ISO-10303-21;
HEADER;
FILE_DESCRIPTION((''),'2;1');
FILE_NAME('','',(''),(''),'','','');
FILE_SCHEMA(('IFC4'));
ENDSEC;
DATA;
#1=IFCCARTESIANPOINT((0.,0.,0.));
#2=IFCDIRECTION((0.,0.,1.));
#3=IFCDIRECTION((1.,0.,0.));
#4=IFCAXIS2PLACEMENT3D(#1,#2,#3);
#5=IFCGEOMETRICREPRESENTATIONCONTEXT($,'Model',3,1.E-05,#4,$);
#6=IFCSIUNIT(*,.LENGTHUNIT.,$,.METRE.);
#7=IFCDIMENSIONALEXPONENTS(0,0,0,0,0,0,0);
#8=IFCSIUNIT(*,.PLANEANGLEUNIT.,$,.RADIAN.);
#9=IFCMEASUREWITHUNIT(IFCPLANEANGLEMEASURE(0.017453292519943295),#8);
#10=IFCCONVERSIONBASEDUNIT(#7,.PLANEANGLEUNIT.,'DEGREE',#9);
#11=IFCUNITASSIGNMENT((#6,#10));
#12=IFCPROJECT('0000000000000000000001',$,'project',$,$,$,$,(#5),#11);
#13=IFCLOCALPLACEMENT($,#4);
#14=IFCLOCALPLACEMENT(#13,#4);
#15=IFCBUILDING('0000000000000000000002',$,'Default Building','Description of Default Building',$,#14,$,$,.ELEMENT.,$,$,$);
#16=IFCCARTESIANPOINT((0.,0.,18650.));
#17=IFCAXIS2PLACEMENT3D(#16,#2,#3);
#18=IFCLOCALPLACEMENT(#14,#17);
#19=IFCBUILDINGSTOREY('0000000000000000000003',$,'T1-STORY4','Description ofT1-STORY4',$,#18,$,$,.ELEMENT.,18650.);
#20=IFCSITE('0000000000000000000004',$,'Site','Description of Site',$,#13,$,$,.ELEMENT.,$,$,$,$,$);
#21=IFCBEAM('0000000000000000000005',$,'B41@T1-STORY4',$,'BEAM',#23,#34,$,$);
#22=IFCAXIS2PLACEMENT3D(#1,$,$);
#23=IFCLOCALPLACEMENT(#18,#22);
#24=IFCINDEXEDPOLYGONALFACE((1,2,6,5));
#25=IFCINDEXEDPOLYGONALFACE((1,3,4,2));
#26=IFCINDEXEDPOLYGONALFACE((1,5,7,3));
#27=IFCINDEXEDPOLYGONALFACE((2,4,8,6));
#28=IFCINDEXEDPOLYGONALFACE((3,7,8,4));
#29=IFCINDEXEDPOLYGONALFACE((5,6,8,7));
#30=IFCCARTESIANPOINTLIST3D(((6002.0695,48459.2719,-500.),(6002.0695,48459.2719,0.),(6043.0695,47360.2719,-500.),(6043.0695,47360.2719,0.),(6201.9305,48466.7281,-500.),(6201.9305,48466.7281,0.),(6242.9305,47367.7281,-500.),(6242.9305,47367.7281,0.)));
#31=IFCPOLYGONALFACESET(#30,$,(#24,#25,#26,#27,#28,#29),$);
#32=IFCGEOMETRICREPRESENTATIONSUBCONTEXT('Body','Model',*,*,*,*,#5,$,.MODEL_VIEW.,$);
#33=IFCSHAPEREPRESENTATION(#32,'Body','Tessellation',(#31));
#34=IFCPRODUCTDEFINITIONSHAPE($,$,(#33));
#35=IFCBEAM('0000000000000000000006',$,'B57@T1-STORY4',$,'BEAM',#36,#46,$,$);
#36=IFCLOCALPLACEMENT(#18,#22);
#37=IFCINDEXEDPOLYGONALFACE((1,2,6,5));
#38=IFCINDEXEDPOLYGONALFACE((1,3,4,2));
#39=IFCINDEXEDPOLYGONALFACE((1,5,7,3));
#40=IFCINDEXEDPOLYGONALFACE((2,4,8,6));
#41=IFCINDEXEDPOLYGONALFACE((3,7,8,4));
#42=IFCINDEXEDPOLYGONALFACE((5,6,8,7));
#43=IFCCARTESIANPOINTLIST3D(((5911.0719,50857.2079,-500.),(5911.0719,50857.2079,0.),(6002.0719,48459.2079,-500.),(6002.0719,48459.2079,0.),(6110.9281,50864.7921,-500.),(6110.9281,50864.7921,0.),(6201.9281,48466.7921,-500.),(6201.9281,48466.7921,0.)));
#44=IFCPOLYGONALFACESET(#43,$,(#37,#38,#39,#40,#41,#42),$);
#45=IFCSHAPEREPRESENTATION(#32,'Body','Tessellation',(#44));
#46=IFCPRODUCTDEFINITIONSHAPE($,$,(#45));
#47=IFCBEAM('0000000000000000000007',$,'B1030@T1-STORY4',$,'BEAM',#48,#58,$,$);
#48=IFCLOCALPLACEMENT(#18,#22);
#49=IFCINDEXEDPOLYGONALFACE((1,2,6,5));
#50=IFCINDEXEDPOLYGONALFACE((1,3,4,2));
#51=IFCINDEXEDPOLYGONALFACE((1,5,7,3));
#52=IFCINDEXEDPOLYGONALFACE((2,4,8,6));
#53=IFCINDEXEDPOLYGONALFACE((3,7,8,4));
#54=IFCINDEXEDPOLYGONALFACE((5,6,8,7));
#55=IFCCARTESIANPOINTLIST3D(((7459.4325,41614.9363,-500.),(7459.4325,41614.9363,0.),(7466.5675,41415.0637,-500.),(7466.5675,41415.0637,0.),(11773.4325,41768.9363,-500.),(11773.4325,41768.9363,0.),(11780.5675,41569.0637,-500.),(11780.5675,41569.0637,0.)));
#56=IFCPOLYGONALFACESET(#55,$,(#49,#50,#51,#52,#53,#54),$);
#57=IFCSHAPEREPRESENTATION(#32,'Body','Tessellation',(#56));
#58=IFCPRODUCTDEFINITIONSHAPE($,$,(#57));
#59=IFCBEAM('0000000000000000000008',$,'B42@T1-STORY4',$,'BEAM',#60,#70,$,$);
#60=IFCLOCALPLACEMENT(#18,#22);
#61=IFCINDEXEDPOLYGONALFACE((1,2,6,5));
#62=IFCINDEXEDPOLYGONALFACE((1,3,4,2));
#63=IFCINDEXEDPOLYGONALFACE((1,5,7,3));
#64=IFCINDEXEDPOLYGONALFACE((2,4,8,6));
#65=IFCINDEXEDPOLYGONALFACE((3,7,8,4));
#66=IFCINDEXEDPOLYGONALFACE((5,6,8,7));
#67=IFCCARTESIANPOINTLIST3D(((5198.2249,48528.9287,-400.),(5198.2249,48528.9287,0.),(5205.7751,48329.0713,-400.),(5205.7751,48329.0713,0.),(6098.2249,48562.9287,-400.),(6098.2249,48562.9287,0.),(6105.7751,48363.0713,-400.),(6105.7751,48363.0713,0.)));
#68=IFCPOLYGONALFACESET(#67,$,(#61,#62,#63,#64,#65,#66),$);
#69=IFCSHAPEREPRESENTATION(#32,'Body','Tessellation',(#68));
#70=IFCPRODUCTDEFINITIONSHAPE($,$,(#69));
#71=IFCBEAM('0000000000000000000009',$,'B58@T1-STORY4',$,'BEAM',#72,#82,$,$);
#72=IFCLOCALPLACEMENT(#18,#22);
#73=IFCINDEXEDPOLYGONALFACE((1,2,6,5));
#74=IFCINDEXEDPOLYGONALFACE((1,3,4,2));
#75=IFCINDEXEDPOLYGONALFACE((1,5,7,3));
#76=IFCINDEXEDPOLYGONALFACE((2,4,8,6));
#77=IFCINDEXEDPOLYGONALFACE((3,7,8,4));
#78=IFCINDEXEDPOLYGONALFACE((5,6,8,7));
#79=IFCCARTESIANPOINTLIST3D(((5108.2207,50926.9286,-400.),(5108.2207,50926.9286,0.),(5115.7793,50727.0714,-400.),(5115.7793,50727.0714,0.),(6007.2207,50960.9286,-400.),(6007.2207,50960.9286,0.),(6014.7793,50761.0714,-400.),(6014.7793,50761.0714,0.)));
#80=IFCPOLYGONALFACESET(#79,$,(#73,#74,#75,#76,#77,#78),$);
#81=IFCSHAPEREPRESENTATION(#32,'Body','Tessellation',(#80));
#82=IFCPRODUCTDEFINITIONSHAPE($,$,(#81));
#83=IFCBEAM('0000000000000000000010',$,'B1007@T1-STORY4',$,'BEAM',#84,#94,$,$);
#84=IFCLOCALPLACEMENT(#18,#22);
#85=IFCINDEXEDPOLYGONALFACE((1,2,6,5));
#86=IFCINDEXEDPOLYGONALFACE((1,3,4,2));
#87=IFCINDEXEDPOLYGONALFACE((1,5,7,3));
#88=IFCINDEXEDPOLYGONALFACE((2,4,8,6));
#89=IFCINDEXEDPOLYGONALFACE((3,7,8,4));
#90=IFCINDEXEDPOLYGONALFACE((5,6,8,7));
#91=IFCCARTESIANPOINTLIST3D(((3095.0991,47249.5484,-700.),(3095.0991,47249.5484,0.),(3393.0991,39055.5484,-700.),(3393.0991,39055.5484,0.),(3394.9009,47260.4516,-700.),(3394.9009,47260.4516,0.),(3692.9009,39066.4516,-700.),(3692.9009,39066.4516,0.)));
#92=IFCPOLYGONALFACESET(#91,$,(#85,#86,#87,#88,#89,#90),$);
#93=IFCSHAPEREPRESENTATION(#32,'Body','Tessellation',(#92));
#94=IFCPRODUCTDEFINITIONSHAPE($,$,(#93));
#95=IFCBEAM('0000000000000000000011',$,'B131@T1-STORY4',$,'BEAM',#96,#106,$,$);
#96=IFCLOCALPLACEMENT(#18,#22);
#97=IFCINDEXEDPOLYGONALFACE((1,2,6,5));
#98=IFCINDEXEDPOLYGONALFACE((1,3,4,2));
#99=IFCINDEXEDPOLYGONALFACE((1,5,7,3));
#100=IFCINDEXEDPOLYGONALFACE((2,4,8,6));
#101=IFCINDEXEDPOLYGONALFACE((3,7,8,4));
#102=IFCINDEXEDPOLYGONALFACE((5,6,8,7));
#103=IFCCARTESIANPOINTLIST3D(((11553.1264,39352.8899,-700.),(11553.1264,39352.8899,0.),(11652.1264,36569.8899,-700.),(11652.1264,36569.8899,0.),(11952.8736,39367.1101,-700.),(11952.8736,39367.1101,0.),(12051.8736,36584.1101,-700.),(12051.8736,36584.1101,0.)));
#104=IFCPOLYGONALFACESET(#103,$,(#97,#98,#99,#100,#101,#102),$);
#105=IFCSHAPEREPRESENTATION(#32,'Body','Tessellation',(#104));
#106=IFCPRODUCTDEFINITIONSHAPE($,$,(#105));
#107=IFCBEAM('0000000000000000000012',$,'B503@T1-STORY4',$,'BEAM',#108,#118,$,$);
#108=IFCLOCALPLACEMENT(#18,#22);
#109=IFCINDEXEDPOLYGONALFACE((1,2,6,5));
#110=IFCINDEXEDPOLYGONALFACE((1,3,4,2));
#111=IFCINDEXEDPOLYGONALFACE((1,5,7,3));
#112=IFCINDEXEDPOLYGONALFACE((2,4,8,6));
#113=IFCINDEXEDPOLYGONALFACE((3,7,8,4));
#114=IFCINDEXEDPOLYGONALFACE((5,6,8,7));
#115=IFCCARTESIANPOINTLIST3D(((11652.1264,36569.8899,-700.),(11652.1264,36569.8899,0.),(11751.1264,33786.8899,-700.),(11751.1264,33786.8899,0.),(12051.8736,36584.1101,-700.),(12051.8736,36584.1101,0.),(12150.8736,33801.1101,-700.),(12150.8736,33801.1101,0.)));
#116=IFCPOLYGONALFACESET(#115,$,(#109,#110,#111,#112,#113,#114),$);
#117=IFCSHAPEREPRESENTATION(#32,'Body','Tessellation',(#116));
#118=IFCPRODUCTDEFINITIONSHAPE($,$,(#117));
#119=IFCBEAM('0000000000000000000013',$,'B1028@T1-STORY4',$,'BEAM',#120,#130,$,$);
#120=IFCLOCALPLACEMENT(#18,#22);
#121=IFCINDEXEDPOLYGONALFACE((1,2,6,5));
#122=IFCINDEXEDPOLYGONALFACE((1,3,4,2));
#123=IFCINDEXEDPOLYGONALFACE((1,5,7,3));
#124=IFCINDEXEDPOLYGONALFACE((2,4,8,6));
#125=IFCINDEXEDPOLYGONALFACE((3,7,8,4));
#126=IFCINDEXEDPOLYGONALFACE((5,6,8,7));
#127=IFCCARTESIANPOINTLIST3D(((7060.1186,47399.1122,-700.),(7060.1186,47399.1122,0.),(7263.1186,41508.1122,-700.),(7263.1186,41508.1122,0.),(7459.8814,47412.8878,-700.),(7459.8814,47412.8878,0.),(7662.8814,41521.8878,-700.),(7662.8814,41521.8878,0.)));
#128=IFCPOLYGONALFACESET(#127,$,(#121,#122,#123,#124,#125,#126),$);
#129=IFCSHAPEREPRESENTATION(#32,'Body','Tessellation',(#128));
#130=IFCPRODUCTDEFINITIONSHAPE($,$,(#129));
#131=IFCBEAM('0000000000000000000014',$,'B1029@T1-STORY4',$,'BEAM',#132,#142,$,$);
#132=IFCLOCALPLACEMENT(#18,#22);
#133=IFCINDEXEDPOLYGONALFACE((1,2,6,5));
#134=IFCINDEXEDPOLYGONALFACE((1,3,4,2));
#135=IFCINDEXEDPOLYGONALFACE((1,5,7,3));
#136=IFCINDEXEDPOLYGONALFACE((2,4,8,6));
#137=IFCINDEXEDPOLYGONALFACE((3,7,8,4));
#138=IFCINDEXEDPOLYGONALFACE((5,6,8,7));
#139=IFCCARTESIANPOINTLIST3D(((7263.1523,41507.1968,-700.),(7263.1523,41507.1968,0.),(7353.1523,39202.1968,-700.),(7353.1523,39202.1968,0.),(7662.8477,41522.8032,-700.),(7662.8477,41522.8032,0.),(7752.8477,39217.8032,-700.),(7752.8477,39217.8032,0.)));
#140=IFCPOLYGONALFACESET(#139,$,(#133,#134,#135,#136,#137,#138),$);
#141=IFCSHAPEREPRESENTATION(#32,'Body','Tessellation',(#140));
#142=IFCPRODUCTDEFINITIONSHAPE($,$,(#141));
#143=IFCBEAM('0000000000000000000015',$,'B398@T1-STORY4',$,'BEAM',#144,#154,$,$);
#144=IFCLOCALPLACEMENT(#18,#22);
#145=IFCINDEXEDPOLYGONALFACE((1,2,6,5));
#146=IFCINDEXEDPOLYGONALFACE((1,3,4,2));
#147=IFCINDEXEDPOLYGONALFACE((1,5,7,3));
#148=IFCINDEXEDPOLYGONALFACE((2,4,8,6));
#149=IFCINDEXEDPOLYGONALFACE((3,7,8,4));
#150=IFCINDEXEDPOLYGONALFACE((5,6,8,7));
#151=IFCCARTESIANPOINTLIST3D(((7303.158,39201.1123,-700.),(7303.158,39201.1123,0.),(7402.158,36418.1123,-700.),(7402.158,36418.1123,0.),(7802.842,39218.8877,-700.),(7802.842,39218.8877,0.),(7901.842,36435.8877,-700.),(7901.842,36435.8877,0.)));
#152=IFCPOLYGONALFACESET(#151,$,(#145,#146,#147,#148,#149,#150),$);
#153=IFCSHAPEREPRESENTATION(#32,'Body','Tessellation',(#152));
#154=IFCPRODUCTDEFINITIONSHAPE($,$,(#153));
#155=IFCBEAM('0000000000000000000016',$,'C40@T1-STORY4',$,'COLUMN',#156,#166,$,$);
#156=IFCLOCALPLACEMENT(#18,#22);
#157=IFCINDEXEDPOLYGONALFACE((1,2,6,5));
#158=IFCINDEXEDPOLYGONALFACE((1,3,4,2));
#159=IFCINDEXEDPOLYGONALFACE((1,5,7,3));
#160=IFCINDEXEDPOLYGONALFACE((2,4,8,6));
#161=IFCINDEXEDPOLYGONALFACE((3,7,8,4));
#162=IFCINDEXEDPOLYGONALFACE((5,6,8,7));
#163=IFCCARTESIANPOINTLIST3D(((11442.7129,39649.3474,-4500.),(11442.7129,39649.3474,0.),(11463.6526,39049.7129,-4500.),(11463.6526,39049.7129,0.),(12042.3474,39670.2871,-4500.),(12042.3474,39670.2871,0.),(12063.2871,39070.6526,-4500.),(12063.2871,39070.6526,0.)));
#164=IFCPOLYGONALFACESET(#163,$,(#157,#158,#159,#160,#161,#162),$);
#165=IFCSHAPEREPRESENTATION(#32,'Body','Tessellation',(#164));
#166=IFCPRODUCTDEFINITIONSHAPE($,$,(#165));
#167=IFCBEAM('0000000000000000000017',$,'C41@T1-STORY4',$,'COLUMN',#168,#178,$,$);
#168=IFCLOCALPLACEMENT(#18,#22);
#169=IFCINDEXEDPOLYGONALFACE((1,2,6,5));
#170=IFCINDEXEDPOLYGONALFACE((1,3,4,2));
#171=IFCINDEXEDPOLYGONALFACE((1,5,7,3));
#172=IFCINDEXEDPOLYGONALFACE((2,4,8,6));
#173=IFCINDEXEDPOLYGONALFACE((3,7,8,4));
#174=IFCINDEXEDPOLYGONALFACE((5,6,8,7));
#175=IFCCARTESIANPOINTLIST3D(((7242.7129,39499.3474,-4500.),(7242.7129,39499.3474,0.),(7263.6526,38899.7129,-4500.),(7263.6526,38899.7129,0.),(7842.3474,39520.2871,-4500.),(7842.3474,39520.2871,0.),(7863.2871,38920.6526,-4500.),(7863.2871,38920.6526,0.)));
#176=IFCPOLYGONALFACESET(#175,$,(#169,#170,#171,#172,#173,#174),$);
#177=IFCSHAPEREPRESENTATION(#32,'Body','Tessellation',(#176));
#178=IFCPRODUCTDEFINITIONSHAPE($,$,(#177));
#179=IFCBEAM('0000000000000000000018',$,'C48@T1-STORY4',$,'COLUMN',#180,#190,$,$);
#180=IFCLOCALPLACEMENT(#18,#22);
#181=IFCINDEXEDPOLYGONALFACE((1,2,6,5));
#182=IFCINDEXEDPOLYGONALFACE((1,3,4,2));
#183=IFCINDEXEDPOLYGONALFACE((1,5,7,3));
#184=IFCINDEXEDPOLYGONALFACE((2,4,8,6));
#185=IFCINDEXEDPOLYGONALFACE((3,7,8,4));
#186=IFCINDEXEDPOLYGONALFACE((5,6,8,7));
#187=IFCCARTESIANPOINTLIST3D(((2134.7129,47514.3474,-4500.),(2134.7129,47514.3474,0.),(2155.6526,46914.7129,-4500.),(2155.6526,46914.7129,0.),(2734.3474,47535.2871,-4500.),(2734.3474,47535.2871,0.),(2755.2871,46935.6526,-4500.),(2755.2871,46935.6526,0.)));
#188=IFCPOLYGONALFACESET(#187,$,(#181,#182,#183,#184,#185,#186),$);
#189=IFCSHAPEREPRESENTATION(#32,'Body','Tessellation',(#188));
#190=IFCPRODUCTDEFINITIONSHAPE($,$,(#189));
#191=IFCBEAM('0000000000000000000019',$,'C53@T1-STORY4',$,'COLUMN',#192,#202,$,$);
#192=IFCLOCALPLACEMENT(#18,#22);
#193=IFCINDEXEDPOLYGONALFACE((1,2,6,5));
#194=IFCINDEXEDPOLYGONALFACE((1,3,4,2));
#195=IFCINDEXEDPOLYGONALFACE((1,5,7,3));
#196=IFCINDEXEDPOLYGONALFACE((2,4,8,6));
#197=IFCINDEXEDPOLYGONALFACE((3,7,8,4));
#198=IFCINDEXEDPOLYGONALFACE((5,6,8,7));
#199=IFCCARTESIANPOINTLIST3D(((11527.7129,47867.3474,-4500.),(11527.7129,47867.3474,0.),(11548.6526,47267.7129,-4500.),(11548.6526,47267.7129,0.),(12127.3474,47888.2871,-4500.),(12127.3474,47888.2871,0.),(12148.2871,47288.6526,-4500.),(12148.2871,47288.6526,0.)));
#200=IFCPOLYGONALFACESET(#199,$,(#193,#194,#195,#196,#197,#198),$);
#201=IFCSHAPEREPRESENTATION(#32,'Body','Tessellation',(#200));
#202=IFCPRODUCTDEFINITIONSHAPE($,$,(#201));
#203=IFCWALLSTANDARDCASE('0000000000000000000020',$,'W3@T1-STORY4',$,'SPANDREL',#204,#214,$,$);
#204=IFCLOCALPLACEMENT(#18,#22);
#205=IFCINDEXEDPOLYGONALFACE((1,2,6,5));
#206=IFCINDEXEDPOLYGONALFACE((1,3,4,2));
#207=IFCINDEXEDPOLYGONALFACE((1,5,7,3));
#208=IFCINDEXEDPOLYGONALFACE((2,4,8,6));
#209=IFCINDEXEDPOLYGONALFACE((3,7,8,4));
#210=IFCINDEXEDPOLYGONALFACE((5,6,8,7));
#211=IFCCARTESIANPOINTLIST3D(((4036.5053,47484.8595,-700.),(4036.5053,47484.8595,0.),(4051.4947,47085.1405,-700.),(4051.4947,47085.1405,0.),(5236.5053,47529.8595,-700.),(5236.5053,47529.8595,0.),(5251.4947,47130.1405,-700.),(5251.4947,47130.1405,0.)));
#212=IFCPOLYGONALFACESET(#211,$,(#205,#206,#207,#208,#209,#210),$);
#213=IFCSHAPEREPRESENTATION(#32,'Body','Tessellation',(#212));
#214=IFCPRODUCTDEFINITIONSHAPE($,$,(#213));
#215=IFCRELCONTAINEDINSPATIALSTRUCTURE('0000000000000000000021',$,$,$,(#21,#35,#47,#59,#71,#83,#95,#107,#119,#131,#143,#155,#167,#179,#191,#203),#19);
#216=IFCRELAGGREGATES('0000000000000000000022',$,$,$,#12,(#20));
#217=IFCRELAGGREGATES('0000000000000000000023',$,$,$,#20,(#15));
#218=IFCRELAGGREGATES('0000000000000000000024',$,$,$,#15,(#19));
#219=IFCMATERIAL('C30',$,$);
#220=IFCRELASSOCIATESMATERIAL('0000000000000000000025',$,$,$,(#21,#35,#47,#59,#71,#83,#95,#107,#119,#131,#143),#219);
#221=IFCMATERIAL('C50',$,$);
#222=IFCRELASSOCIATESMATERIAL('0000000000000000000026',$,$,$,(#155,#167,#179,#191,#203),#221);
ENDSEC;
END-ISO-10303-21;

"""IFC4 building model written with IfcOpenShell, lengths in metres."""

from ifc_helpers import new_model, entity, si_unit, converted_unit, frame, origin_with_axes, place, context, subcontext, project, spatial, indexed_curve, rectangle, outline, extrude, material, element, save


model = new_model("IFC4")

# Units and contexts
model_context = context("Model", 3, precision=1e-05, world=origin_with_axes())
body_context = subcontext(model_context, "Body", "Model", "MODEL_VIEW")
ifc_project = project(units=[si_unit("LENGTHUNIT", "METRE"), converted_unit("PLANEANGLEUNIT", "DEGREE", entity("IfcPlaneAngleMeasure", 0.017453292519943295), si_unit("PLANEANGLEUNIT", "RADIAN"), dimensions=[0, 0, 0, 0, 0, 0, 0])], contexts=[model_context])

# Site, building, storey
site_placement = place(None, origin_with_axes())
site = spatial("IfcSite", under=ifc_project, at=site_placement, Name="Site", Description="Description of Site", CompositionType="ELEMENT")
building_placement = place(site_placement, origin_with_axes())
building = spatial("IfcBuilding", under=site, at=building_placement, Name="Default Building", Description="Description of Default Building", CompositionType="ELEMENT")
storey_placement = place(building_placement, frame((0.0, 0.0, 18650.0), z_axis=(0.0, 0.0, 1.0), x_axis=(1.0, 0.0, 0.0)))
storey = spatial("IfcBuildingStorey", under=building, at=storey_placement, Name="T1-STORY4", Description="Description ofT1-STORY4", CompositionType="ELEMENT", Elevation=18650.0)

# Beams
ifc_material_1 = material(Name="C30")
beam_1_placement = place(storey_placement, frame((6102.0, 48463.0, -250.0), z_axis=(0.037281, -0.999305, 0.0), x_axis=(0.999305, 0.037281, 0.0)))
element("IfcBeam", 1, at=beam_1_placement, inside=storey, material=ifc_material_1, Name="B41@T1-STORY4", ObjectType="BEAM", context=body_context, shape_type="SweptSolid", body=[
    extrude(rectangle(XDim=200.0, YDim=500.0), origin_with_axes(), (0.0, 0.0, 1.0), 1099.7645),
])
beam_2_placement = place(storey_placement, frame((6011.0, 50861.0, -250.0), z_axis=(0.037921, -0.999281, 0.0), x_axis=(0.999281, 0.037921, 0.0)))
element("IfcBeam", 2, at=beam_2_placement, inside=storey, material=ifc_material_1, Name="B57@T1-STORY4", ObjectType="BEAM", context=body_context, shape_type="SweptSolid", body=[
    extrude(rectangle(XDim=200.0, YDim=500.0), origin_with_axes(), (0.0, 0.0, 1.0), 2399.726),
])
beam_3_placement = place(storey_placement, frame((7463.0, 41515.0, -250.0), z_axis=(0.999363, 0.035675, 0.0), x_axis=(-0.035675, 0.999363, 0.0)))
element("IfcBeam", 3, at=beam_3_placement, inside=storey, material=ifc_material_1, Name="B1030@T1-STORY4", ObjectType="BEAM", context=body_context, shape_type="SweptSolid", body=[
    extrude(rectangle(XDim=200.0, YDim=500.0), origin_with_axes(), (0.0, 0.0, 1.0), 4316.7478),
])
beam_4_placement = place(storey_placement, frame((5202.0, 48429.0, -200.0), z_axis=(0.999287, 0.037751, 0.0), x_axis=(-0.037751, 0.999287, 0.0)))
element("IfcBeam", 4, at=beam_4_placement, inside=storey, material=ifc_material_1, Name="B42@T1-STORY4", ObjectType="BEAM", context=body_context, shape_type="SweptSolid", body=[
    extrude(rectangle(XDim=200.0, YDim=400.0), origin_with_axes(), (0.0, 0.0, 1.0), 900.642),
])
beam_5_placement = place(storey_placement, frame((5112.0, 50827.0, -200.0), z_axis=(0.999286, 0.037793, 0.0), x_axis=(-0.037793, 0.999286, 0.0)))
element("IfcBeam", 5, at=beam_5_placement, inside=storey, material=ifc_material_1, Name="B58@T1-STORY4", ObjectType="BEAM", context=body_context, shape_type="SweptSolid", body=[
    extrude(rectangle(XDim=200.0, YDim=400.0), origin_with_axes(), (0.0, 0.0, 1.0), 899.6427),
])
beam_6_placement = place(storey_placement, frame((3245.0, 47255.0, -350.0), z_axis=(0.036344, -0.999339, 0.0), x_axis=(0.999339, 0.036344, 0.0)))
element("IfcBeam", 6, at=beam_6_placement, inside=storey, material=ifc_material_1, Name="B1007@T1-STORY4", ObjectType="BEAM", context=body_context, shape_type="SweptSolid", body=[
    extrude(rectangle(XDim=300.0, YDim=700.0), origin_with_axes(), (0.0, 0.0, 1.0), 8199.4171),
])
for number, where, z_axis, x_axis, name in (
    (7, (11753.0, 39360.0, -350.0), (0.035551, -0.999368, 0.0), (0.999368, 0.035551, 0.0), "B131@T1-STORY4"),
    (8, (11852.0, 36577.0, -350.0), (0.035551, -0.999368, 0.0), (0.999368, 0.035551, 0.0), "B503@T1-STORY4"),
):
    element("IfcBeam", number, at=place(storey_placement, frame(where, z_axis=z_axis, x_axis=x_axis)), inside=storey, material=ifc_material_1, Name=name, ObjectType="BEAM", context=body_context, shape_type="SweptSolid", body=[
        extrude(rectangle(XDim=400.0, YDim=700.0), origin_with_axes(), (0.0, 0.0, 1.0), 2784.7603),
    ])
beam_7_placement = place(storey_placement, frame((7260.0, 47406.0, -350.0), z_axis=(0.034439, -0.999407, 0.0), x_axis=(0.999407, 0.034439, 0.0)))
element("IfcBeam", 9, at=beam_7_placement, inside=storey, material=ifc_material_1, Name="B1028@T1-STORY4", ObjectType="BEAM", context=body_context, shape_type="SweptSolid", body=[
    extrude(rectangle(XDim=400.0, YDim=700.0), origin_with_axes(), (0.0, 0.0, 1.0), 5894.4966),
])
beam_8_placement = place(storey_placement, frame((7463.0, 41515.0, -350.0), z_axis=(0.039016, -0.999239, 0.0), x_axis=(0.999239, 0.039016, 0.0)))
element("IfcBeam", 10, at=beam_8_placement, inside=storey, material=ifc_material_1, Name="B1029@T1-STORY4", ObjectType="BEAM", context=body_context, shape_type="SweptSolid", body=[
    extrude(rectangle(XDim=400.0, YDim=700.0), origin_with_axes(), (0.0, 0.0, 1.0), 2306.7564),
])
beam_9_placement = place(storey_placement, frame((7553.0, 39210.0, -350.0), z_axis=(0.035551, -0.999368, 0.0), x_axis=(0.999368, 0.035551, 0.0)))
element("IfcBeam", 11, at=beam_9_placement, inside=storey, material=ifc_material_1, Name="B398@T1-STORY4", ObjectType="BEAM", context=body_context, shape_type="SweptSolid", body=[
    extrude(rectangle(XDim=500.0, YDim=700.0), origin_with_axes(), (0.0, 0.0, 1.0), 2784.7603),
])
ifc_material_2 = material(Name="C50")
for number, where, z_axis, x_axis, name in (
    (12, (11753.0, 39360.0, -4500.0), (0.0, 0.0, 1.0), (-0.999391, -0.034899, 0.0), "C40@T1-STORY4"),
    (13, (7553.0, 39210.0, -4500.0), (0.0, 0.0, 1.0), (-0.999391, -0.034899, 0.0), "C41@T1-STORY4"),
    (14, (2445.0, 47225.0, -4500.0), (0.0, 0.0, 1.0), (-0.999391, -0.034899, 0.0), "C48@T1-STORY4"),
    (15, (11838.0, 47578.0, -4500.0), (0.0, 0.0, 1.0), (-0.999391, -0.034899, 0.0), "C53@T1-STORY4"),
):
    element("IfcBeam", number, at=place(storey_placement, frame(where, z_axis=z_axis, x_axis=x_axis)), inside=storey, material=ifc_material_2, Name=name, ObjectType="COLUMN", context=body_context, shape_type="SweptSolid", body=[
        extrude(rectangle(XDim=600.0, YDim=600.0), origin_with_axes(), (0.0, 0.0, 1.0), 4500.0),
    ])

# Wall
wall_1_placement = place(storey_placement, frame((4044.0, 47285.0, -700.0), z_axis=(0.0, 0.0, 1.0), x_axis=(0.999298, 0.037474, 0.0)))
element("IfcWallStandardCase", 16, at=wall_1_placement, inside=storey, material=ifc_material_2, Name="W3@T1-STORY4", ObjectType="SPANDREL", context=body_context, shape_type="SweptSolid", body=[
    extrude(outline(indexed_curve([(0.0, -200.0), (0.0, 200.0), (1200.8435, 200.0), (1200.8435, -200.0), (0.0, -200.0)], self_intersect=False)), origin_with_axes(), (0.0, 0.0, 1.0), 700.0),
])

save(model, "model.ifc")
